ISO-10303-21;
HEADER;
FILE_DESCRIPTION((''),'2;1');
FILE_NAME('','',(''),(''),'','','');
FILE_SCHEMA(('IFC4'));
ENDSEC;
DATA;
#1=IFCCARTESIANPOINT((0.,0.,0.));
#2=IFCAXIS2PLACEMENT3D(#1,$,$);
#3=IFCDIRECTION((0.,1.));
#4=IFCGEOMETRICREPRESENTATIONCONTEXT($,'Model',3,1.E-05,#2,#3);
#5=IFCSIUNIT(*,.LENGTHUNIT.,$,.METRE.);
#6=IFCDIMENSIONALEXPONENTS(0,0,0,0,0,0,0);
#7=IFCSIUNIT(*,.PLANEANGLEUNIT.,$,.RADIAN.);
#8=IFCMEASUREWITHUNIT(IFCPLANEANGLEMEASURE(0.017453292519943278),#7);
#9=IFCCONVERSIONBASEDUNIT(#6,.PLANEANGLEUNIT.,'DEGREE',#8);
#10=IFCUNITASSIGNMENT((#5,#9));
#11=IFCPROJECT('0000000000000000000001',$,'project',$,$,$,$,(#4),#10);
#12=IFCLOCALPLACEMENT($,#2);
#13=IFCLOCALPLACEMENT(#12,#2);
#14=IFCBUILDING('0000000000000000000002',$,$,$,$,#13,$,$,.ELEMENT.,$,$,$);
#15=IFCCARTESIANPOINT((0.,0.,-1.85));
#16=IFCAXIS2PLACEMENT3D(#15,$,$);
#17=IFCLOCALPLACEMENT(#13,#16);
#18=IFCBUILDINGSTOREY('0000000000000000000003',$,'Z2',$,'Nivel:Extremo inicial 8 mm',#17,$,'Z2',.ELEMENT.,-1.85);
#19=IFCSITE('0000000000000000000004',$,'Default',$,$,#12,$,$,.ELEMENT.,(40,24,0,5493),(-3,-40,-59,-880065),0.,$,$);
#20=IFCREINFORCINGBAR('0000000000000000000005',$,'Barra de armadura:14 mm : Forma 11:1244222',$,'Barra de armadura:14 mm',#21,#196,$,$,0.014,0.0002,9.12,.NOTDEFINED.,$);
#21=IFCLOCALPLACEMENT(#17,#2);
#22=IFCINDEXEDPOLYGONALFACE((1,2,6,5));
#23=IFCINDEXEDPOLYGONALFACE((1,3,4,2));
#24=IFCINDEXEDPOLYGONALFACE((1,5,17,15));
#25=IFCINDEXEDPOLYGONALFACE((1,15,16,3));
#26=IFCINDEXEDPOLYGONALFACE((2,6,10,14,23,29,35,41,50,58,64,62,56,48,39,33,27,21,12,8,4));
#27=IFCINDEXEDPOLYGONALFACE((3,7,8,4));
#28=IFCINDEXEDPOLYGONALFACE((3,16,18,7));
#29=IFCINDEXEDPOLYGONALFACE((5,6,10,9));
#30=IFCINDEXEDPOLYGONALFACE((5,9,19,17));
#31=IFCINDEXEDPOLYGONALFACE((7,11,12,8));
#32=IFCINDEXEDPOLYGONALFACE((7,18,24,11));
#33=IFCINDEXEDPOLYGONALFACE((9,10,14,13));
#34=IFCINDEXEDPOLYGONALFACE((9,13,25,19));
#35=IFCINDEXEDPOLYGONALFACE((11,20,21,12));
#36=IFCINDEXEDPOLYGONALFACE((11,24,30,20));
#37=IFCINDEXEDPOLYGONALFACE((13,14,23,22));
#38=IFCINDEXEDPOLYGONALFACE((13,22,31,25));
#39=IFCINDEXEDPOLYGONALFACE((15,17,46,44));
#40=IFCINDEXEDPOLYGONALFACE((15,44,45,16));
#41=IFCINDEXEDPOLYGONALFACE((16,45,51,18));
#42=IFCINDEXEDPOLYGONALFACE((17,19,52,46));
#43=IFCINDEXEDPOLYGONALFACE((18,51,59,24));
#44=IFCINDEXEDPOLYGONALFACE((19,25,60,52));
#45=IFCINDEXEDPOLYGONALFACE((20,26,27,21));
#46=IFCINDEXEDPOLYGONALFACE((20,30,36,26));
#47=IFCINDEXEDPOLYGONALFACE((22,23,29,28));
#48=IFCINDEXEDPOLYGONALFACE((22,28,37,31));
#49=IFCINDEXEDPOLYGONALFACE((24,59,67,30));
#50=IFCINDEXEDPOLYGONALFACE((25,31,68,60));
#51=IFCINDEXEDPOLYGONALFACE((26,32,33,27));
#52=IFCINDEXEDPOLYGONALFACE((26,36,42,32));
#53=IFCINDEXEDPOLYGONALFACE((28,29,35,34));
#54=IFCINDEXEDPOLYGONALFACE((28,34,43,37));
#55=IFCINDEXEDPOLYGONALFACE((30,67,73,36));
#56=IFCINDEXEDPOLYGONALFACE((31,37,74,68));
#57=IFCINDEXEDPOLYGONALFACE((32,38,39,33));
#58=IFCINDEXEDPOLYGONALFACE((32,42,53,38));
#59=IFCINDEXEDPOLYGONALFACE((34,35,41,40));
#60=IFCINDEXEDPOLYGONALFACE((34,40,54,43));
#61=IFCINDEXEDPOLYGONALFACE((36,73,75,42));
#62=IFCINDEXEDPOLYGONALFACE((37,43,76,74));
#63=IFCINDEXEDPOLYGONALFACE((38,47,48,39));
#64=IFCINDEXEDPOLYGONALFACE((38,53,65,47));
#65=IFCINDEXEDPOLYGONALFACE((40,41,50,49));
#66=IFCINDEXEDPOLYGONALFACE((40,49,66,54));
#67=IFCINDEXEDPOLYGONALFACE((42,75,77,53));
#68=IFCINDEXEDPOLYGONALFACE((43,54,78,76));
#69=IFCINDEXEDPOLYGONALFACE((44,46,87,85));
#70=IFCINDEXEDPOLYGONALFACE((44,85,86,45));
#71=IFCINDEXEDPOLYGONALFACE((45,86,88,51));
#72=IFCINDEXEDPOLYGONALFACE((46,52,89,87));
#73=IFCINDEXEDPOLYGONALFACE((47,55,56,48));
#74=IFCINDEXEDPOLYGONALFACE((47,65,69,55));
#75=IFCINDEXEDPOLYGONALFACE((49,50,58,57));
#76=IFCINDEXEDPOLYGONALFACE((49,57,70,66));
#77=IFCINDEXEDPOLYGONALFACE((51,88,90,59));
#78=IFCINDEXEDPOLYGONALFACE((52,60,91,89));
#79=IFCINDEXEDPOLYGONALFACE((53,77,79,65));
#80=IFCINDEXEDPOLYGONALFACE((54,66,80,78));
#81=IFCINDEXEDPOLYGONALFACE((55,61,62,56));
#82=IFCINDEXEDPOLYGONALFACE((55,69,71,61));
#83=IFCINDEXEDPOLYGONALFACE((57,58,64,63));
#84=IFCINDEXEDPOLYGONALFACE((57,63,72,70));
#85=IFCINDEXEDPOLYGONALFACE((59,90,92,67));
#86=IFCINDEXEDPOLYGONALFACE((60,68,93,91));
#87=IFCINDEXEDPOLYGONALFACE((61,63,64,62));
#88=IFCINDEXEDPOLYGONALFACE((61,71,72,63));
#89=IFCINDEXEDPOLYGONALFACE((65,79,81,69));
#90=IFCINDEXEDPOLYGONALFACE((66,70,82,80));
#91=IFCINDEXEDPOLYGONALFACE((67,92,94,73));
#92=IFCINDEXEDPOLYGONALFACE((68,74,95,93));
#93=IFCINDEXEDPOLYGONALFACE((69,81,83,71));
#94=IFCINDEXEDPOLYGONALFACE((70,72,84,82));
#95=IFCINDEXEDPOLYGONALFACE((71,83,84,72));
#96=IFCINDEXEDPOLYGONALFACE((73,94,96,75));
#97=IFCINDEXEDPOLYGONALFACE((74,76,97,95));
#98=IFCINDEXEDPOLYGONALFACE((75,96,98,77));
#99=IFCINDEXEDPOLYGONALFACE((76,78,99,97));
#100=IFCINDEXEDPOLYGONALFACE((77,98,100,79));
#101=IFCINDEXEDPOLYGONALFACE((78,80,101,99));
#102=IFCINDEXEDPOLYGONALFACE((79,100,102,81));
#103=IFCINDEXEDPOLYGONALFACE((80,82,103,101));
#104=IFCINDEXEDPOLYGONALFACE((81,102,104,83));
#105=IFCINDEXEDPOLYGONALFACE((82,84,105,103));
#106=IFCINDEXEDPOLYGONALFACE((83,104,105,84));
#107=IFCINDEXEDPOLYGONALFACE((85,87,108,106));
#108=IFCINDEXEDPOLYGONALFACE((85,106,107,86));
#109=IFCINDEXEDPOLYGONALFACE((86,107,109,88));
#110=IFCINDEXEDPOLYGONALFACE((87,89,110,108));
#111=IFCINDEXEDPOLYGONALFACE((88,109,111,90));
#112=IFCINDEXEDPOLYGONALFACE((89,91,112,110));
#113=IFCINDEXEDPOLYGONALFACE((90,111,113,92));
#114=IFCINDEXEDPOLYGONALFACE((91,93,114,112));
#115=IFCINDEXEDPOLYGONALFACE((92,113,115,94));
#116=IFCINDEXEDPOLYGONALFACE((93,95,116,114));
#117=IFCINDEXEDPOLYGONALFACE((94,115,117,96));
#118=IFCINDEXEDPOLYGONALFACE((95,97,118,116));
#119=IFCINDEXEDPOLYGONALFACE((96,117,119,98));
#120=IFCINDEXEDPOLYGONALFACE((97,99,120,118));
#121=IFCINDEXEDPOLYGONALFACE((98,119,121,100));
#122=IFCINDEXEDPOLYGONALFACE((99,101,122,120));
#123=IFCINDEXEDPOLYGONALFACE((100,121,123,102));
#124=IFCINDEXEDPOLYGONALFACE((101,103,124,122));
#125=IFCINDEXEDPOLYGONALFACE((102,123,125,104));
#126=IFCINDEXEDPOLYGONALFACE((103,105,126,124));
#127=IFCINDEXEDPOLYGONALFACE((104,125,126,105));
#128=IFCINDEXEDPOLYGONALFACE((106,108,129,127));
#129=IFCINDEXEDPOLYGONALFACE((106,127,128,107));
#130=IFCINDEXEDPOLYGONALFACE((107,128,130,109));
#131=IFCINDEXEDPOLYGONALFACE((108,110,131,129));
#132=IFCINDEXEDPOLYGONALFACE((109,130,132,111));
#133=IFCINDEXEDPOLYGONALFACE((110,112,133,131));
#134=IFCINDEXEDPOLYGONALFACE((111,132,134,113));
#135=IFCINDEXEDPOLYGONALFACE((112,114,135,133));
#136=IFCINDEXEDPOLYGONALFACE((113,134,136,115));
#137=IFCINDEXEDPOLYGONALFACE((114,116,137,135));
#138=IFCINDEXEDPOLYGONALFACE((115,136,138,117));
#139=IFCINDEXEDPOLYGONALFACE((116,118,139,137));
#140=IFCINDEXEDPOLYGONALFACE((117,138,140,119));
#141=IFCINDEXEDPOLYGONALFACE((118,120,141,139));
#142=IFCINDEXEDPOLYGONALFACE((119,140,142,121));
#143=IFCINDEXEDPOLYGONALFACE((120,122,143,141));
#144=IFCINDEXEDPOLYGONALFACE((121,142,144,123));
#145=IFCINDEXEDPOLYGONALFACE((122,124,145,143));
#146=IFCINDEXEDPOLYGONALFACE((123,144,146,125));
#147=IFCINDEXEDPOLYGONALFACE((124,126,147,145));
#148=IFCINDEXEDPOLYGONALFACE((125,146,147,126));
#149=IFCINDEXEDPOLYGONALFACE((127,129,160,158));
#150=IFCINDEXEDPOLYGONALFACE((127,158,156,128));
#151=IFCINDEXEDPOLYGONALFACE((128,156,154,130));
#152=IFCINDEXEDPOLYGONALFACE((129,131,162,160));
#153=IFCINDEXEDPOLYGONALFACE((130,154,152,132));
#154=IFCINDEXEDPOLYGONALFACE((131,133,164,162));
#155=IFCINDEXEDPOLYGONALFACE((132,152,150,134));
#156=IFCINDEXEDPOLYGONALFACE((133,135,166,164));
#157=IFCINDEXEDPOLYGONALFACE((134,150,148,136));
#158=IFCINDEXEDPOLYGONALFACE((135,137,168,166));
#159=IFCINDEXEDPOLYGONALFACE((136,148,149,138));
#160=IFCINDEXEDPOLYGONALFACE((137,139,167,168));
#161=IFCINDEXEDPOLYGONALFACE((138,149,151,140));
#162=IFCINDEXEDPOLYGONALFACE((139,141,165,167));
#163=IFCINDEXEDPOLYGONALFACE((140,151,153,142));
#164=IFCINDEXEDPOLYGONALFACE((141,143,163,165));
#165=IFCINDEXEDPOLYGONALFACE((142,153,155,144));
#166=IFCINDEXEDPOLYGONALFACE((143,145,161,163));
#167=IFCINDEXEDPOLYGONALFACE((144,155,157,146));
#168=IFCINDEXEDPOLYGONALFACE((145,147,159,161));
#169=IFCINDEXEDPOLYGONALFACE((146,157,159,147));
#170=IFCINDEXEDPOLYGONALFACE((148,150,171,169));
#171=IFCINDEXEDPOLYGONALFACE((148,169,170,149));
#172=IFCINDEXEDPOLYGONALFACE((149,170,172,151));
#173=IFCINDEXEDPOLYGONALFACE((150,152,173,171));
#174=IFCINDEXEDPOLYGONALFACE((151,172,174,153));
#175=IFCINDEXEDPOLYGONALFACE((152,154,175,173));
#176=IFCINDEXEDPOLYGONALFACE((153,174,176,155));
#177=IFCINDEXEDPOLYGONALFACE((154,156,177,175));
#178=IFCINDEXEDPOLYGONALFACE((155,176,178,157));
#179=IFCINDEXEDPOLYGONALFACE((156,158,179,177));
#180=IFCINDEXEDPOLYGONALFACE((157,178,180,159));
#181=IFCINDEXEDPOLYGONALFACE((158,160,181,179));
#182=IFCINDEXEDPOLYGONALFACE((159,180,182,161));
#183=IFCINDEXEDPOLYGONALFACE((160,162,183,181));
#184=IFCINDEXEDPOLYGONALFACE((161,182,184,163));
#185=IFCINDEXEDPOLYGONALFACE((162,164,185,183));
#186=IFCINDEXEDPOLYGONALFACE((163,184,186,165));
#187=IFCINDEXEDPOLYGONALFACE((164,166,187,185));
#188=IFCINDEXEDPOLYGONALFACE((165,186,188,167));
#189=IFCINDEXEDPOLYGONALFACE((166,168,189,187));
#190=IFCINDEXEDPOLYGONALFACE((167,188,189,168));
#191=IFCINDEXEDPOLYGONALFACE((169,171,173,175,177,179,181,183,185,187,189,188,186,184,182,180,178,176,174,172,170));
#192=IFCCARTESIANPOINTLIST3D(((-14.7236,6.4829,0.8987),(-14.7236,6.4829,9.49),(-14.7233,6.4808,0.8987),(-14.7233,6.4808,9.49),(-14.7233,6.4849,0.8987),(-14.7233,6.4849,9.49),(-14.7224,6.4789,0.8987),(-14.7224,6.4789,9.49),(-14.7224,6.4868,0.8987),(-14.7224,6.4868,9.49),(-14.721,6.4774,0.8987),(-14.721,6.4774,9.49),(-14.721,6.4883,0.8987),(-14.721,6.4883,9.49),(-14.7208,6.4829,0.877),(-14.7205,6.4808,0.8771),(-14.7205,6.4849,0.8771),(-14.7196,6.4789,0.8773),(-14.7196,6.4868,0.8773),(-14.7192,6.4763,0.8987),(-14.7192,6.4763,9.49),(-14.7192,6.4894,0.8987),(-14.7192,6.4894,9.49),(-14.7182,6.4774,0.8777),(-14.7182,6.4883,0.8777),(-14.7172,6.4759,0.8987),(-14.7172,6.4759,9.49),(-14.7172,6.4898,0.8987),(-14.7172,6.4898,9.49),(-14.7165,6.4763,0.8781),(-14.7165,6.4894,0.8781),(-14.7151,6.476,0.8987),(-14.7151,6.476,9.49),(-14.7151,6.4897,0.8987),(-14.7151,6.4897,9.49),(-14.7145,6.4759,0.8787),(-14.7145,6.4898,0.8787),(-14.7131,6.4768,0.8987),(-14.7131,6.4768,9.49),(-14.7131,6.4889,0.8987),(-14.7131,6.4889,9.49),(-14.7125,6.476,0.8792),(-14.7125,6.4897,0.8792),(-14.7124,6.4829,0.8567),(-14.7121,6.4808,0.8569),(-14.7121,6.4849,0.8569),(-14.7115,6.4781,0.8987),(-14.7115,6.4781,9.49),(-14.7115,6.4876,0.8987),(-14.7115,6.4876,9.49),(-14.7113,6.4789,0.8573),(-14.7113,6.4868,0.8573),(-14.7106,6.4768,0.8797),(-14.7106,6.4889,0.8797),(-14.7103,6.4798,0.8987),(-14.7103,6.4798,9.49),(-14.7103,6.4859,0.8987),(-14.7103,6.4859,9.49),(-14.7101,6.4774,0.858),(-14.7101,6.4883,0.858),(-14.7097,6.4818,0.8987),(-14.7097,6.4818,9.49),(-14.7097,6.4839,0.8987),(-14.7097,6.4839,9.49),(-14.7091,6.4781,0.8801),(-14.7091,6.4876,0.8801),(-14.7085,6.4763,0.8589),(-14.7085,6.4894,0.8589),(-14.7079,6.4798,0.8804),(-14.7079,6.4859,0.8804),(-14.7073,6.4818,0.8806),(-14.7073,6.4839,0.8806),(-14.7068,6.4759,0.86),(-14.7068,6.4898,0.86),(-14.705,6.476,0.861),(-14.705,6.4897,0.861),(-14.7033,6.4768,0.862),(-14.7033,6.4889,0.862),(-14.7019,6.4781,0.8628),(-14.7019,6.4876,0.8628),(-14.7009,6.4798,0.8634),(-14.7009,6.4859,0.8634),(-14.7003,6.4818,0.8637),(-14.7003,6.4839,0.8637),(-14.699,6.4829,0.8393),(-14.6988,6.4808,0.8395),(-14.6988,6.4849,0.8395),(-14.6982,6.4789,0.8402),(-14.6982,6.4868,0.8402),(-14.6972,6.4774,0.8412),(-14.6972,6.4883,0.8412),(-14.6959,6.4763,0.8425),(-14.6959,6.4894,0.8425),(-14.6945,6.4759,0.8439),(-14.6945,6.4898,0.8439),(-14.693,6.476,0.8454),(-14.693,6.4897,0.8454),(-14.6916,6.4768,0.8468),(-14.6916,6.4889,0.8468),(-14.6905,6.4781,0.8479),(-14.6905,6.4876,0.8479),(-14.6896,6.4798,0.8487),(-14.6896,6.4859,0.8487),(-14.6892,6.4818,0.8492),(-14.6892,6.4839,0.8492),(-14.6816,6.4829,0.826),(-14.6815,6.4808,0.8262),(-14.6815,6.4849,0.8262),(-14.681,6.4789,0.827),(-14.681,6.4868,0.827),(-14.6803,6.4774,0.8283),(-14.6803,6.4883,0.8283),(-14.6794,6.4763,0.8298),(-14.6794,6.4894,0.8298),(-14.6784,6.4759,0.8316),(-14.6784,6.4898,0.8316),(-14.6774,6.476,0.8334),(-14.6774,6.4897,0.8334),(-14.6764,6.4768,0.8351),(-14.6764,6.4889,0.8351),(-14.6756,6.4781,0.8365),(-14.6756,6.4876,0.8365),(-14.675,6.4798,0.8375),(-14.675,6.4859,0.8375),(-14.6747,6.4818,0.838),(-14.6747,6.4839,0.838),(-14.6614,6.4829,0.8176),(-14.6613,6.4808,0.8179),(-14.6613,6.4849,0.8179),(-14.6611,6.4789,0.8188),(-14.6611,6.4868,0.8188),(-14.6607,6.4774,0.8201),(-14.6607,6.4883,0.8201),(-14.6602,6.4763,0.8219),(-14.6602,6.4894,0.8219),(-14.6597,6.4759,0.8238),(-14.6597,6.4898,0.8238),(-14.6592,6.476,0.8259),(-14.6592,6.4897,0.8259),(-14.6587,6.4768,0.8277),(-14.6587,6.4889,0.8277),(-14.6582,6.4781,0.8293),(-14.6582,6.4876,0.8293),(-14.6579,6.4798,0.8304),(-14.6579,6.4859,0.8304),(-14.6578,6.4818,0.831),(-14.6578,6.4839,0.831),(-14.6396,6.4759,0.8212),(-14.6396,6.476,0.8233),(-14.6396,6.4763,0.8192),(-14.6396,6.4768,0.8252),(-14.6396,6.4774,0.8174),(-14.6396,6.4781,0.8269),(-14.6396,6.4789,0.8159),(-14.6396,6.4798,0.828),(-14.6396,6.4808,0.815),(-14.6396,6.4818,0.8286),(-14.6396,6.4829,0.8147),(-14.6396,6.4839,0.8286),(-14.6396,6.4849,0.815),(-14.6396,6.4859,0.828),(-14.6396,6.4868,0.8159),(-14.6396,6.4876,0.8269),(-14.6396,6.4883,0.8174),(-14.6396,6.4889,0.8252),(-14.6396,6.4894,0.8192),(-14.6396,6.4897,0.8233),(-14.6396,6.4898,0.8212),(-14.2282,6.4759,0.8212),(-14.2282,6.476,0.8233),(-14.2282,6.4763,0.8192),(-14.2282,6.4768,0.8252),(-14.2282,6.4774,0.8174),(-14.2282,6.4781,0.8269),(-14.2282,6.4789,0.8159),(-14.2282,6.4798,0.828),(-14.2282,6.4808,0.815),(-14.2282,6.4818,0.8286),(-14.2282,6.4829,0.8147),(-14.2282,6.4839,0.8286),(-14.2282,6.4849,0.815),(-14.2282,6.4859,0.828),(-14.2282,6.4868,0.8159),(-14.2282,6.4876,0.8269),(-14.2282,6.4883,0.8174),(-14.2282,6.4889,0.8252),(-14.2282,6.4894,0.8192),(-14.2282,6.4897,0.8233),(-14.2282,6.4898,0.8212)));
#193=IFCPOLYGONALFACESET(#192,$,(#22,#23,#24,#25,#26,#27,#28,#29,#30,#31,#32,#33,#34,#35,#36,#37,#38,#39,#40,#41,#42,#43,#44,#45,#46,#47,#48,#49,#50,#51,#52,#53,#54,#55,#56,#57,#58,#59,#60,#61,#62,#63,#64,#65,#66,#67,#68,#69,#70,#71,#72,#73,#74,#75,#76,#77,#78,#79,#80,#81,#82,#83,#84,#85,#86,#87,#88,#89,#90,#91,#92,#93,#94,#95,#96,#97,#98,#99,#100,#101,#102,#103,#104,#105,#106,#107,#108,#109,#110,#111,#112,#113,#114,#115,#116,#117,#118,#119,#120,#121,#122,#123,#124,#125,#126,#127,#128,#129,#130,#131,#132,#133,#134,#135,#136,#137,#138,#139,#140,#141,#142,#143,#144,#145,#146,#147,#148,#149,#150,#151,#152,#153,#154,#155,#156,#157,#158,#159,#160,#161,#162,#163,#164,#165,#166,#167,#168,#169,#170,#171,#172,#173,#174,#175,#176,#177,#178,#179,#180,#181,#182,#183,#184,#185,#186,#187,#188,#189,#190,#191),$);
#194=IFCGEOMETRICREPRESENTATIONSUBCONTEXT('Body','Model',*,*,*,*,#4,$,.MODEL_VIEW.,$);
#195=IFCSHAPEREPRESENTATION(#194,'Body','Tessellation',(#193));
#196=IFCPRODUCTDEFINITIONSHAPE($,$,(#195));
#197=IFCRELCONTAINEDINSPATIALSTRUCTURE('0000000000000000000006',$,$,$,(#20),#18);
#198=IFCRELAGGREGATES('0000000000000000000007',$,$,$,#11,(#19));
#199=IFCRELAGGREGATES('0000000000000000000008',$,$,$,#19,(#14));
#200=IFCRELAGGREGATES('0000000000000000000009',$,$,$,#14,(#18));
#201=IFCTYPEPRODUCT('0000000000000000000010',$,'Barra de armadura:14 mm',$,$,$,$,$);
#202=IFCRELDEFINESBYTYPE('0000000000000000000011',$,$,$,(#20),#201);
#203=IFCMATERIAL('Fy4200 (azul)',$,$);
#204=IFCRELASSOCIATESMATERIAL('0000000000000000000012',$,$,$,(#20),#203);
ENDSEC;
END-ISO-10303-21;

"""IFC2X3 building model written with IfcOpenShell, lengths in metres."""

from ifc_helpers import new_model, entity, si_unit, converted_unit, direction, frame, origin, place, context, subcontext, project, spatial, material, type_object, element, save


model = new_model("IFC2X3")

# Units and contexts
model_context = context("Model", 3, precision=1e-05, world=origin(), true_north=direction((0.0, 1.0)))
body_context = subcontext(model_context, "Body", "Model", "MODEL_VIEW")
ifc_project = project(units=[si_unit("LENGTHUNIT", "METRE"), converted_unit("PLANEANGLEUNIT", "DEGREE", entity("IfcPlaneAngleMeasure", 0.017453292519943278), si_unit("PLANEANGLEUNIT", "RADIAN"), dimensions=[0, 0, 0, 0, 0, 0, 0])], contexts=[model_context])

# Site, building, storey
site_placement = place(None, origin())
site = spatial("IfcSite", under=ifc_project, at=site_placement, Name="Default", CompositionType="ELEMENT", RefLatitude=(40, 24, 0, 5493), RefLongitude=(-3, -40, -59, -880065), RefElevation=0.0)
building_placement = place(site_placement, origin())
building = spatial("IfcBuilding", under=site, at=building_placement, CompositionType="ELEMENT")
storey_placement = place(building_placement, frame((0.0, 0.0, -1.85)))
storey = spatial("IfcBuildingStorey", under=building, at=storey_placement, Name="Z2", ObjectType="Nivel:Extremo inicial 8 mm", LongName="Z2", CompositionType="ELEMENT", Elevation=-1.85)

# Reinforcing bar
ifc_material_1 = material(Name="Fy4200 (azul)")
type_product_1 = type_object("IfcTypeProduct", Name="Barra de armadura:14 mm")
reinforcing_bar_1_placement = place(storey_placement, origin())
element("IfcReinforcingBar", 1, at=reinforcing_bar_1_placement, inside=storey, type_object=type_product_1, material=ifc_material_1, Name="Barra de armadura:14 mm : Forma 11:1244222", ObjectType="Barra de armadura:14 mm", BarLength=9.12, BarRole="NOTDEFINED", CrossSectionArea=0.0002, NominalDiameter=0.014, context=body_context, shape_type="AdvancedSweptSolid", body=[
    entity("IfcSweptDiskSolid", entity("IfcCompositeCurve", [entity("IfcCompositeCurveSegment", "CONTINUOUS", True, entity("IfcPolyline", [entity("IfcCartesianPoint", [-14.7166, 6.4829, 9.49]), entity("IfcCartesianPoint", [-14.7166, 6.4829, 0.8987])])), entity("IfcCompositeCurveSegment", "CONTINUOUS", True, entity("IfcTrimmedCurve", entity("IfcCircle", entity("IfcAxis2Placement3D", entity("IfcCartesianPoint", [-14.6396, 6.4829, 0.8987]), entity("IfcDirection", [0.0, -1.0, 0.0]), entity("IfcDirection", [0.0, 0.0, -1.0])), 0.077), [entity("IfcParameterValue", 270.0)], [entity("IfcParameterValue", 360.0)], True, "PARAMETER")), entity("IfcCompositeCurveSegment", "CONTINUOUS", True, entity("IfcPolyline", [entity("IfcCartesianPoint", [-14.6396, 6.4829, 0.8217]), entity("IfcCartesianPoint", [-14.2282, 6.4829, 0.8217])]))], False), 0.007, None, 0.0, 92.0),
])

save(model, "model.ifc")
